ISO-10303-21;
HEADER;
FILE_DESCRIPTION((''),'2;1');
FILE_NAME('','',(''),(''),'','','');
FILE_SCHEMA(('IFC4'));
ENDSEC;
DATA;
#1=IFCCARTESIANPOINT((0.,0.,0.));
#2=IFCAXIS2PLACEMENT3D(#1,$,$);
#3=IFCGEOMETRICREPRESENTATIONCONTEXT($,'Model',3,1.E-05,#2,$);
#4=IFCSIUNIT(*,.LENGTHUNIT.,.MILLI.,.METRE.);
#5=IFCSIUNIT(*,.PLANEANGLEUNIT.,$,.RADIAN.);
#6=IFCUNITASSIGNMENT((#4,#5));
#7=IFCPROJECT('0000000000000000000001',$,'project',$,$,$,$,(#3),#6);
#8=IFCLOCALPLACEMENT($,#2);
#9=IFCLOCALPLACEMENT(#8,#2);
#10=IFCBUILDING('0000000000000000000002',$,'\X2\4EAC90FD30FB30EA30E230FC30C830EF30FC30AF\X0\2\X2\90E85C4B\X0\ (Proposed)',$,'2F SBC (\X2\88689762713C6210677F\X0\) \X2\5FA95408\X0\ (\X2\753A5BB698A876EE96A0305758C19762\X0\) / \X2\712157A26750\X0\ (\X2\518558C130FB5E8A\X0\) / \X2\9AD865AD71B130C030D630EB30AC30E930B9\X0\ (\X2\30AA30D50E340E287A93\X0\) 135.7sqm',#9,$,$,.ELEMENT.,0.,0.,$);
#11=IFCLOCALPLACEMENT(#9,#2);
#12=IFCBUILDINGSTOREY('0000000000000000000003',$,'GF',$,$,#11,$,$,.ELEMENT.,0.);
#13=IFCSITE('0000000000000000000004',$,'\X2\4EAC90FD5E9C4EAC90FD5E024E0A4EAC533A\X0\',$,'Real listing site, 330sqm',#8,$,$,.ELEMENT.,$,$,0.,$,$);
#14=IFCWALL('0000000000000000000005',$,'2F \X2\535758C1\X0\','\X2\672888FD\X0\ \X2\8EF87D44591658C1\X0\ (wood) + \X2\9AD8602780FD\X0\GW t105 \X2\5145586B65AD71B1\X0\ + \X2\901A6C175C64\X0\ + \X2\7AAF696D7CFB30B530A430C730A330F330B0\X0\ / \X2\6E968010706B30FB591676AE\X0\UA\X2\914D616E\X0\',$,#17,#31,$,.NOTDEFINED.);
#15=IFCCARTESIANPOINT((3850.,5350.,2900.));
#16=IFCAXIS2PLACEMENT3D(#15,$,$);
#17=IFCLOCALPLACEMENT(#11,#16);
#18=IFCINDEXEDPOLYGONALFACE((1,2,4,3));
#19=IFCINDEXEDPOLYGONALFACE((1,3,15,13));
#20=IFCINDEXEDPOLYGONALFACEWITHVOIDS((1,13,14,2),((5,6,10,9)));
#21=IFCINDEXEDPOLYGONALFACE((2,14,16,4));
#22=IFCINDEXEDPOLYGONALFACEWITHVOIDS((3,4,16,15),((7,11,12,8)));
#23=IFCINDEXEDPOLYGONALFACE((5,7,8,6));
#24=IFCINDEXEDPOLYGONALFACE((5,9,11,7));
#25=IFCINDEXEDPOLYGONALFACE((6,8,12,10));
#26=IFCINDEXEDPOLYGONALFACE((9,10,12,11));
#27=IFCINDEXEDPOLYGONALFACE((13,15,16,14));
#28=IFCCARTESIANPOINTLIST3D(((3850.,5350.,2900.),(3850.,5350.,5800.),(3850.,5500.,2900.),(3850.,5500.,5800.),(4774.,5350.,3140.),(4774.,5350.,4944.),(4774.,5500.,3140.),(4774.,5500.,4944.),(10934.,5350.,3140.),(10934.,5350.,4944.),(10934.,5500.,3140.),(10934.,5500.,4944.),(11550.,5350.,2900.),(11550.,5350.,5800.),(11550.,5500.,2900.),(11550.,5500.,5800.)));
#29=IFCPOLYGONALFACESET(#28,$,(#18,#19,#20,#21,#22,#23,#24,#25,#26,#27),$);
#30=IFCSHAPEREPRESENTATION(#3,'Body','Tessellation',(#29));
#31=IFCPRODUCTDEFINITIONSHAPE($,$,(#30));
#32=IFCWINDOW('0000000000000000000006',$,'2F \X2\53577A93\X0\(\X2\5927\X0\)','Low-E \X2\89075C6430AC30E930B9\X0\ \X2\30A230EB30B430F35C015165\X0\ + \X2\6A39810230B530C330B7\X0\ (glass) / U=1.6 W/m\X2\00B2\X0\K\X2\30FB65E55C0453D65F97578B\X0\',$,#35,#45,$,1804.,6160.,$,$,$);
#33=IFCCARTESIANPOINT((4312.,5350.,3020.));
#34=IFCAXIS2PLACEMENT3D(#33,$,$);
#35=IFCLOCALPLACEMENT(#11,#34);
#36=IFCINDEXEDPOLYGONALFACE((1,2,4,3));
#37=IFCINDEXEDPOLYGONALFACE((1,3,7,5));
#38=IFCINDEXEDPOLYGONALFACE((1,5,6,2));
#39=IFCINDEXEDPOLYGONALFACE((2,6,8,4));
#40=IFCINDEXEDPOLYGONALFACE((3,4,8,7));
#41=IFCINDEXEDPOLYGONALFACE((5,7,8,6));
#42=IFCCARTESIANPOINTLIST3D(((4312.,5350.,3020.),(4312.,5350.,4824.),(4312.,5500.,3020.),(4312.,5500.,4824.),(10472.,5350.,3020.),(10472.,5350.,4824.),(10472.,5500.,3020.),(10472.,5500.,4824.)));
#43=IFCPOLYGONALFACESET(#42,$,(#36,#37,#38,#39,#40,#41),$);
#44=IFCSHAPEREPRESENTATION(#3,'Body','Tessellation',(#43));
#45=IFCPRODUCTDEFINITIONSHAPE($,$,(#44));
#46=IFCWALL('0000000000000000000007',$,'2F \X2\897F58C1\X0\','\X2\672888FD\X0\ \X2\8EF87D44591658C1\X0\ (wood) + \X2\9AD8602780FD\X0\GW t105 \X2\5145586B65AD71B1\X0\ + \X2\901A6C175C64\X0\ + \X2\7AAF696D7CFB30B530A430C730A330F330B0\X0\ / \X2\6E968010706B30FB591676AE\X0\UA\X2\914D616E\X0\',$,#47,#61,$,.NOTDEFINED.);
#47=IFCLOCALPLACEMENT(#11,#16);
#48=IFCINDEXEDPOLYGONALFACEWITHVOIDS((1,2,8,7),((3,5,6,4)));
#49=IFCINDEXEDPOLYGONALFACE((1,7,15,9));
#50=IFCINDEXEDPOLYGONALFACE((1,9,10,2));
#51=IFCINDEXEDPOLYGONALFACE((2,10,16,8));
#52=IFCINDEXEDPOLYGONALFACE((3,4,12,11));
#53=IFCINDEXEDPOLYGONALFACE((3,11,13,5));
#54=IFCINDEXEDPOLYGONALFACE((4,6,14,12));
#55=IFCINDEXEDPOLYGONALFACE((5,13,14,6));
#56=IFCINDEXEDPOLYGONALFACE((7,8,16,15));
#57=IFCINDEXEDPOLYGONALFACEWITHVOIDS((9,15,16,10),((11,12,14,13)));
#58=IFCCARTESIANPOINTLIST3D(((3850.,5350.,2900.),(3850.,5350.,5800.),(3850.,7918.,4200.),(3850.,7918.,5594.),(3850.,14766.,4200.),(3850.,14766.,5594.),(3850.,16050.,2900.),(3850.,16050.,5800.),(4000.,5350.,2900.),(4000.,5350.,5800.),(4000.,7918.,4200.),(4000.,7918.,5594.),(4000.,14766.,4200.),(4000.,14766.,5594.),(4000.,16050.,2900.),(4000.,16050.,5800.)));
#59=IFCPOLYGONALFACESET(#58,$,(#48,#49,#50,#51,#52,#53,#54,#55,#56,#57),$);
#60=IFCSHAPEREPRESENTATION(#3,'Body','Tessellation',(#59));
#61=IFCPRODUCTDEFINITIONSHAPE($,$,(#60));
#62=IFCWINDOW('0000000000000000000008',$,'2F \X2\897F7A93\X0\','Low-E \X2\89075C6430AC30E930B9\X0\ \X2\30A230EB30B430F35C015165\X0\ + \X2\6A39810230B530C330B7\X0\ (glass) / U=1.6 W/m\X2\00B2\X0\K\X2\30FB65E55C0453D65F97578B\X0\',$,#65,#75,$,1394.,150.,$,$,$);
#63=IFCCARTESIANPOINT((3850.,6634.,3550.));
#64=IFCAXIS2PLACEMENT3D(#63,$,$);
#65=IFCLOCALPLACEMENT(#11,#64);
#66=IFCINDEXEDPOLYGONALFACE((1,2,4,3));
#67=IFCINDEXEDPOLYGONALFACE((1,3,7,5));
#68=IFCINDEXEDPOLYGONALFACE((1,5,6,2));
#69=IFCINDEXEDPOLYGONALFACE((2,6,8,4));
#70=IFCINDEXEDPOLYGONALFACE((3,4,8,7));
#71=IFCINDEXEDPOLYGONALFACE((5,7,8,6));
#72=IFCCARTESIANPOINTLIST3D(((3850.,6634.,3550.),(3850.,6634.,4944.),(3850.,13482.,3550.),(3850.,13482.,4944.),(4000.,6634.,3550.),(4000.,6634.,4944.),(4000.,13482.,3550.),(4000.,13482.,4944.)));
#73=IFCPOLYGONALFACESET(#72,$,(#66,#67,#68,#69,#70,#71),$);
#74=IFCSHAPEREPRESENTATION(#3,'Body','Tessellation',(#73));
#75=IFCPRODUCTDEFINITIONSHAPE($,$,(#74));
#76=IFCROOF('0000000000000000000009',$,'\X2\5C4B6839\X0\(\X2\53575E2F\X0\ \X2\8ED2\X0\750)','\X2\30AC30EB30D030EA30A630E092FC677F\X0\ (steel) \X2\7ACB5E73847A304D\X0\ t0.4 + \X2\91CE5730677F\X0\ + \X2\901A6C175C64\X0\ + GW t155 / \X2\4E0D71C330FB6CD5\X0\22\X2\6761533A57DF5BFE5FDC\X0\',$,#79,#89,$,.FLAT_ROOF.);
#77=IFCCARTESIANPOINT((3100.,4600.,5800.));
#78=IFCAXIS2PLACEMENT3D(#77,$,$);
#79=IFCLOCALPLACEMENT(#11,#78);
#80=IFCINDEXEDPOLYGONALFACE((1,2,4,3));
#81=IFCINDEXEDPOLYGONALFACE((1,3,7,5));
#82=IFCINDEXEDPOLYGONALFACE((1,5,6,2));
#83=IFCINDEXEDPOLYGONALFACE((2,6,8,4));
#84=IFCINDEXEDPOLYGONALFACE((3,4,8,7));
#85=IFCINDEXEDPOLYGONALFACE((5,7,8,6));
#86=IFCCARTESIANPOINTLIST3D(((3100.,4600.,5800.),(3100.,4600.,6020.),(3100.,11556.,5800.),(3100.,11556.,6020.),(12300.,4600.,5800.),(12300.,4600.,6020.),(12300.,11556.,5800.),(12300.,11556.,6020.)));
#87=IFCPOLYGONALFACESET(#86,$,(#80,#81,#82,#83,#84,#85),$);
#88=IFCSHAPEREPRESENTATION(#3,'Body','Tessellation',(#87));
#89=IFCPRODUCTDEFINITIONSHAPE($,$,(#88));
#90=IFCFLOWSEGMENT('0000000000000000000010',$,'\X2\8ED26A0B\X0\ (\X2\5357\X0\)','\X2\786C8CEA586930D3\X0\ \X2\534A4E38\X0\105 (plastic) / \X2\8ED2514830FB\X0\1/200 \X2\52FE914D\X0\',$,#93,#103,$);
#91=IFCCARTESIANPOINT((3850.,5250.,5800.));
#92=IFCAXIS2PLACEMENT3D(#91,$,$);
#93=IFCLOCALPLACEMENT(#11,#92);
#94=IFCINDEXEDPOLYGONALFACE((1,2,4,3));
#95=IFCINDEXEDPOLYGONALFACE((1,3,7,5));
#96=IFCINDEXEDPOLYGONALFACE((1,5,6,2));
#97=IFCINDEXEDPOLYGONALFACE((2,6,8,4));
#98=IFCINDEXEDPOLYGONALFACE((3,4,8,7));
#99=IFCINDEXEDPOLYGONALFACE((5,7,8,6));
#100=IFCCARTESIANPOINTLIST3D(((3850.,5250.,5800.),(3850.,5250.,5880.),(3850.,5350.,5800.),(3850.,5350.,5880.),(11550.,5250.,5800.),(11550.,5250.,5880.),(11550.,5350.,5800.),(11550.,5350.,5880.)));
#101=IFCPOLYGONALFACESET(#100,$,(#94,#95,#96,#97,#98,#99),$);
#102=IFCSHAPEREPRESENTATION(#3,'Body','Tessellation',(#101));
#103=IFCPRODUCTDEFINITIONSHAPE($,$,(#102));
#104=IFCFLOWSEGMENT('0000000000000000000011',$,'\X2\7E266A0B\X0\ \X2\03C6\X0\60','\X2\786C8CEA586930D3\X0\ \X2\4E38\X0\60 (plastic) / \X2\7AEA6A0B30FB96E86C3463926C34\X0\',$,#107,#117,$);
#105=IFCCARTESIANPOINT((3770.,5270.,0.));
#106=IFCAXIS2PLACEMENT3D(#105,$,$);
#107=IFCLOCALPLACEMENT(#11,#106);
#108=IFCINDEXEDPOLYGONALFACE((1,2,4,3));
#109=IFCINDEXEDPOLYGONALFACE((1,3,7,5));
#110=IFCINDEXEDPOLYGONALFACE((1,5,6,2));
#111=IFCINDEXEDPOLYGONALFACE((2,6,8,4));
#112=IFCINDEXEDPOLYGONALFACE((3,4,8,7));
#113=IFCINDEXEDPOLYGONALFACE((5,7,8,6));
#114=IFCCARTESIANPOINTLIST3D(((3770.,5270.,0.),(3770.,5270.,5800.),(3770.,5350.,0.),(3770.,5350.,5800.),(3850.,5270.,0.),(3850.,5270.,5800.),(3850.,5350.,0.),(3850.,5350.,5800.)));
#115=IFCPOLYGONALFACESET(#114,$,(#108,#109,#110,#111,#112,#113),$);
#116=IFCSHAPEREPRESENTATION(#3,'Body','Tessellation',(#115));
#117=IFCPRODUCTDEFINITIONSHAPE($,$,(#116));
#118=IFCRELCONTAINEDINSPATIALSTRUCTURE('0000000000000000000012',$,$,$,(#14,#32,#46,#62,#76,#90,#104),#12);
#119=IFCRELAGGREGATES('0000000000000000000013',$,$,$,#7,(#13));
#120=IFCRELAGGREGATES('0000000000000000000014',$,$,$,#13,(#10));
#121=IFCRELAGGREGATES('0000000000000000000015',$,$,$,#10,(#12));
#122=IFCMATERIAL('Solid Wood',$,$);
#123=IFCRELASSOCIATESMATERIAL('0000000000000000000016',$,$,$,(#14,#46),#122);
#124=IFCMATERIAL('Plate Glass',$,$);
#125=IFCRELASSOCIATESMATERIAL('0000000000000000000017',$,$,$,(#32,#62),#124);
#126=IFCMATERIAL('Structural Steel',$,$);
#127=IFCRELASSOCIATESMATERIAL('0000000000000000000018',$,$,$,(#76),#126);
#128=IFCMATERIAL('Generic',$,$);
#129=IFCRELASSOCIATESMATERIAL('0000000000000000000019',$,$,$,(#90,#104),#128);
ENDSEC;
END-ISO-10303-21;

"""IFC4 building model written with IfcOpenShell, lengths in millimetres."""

from ifc_helpers import new_model, si_unit, frame, frame_2d, origin, place, context, project, spatial, rectangle, extrude, material, element, fill, save


model = new_model("IFC4")

# Units and contexts
model_context = context("Model", 3, precision=1e-05, world=origin())
ifc_project = project(units=[si_unit("LENGTHUNIT", "METRE", prefix="MILLI"), si_unit("PLANEANGLEUNIT", "RADIAN")], contexts=[model_context])

# Site, building, storey
site_placement = place(None, origin())
site = spatial("IfcSite", under=ifc_project, at=site_placement, Name="京都府京都市上京区", ObjectType="Real listing site, 330sqm", CompositionType="ELEMENT", RefElevation=0.0)
building_placement = place(site_placement, origin())
building = spatial("IfcBuilding", under=site, at=building_placement, Name="京都・リモートワーク2部屋 (Proposed)", ObjectType="2F SBC (表面焼成板) 復合 (町家風目隠し壁面) / 無垢材 (内壁・床) / 高断熱ダブルガラス (オフิศ窓) 135.7sqm", CompositionType="ELEMENT", ElevationOfRefHeight=0.0, ElevationOfTerrain=0.0)
storey_placement = place(building_placement, origin())
storey = spatial("IfcBuildingStorey", under=building, at=storey_placement, Name="GF", CompositionType="ELEMENT", Elevation=0.0)

# Shared definitions
ifc_material_1 = material(Name="Solid Wood")

# Shared definitions
ifc_material_2 = material(Name="Plate Glass")

# Walls, openings, windows
wall_1_placement = place(storey_placement, frame((3850.0, 5350.0, 2900.0)))
wall_1 = element("IfcWall", 1, at=wall_1_placement, inside=storey, material=ifc_material_1, Name="2F 南壁", Description="木製 軸組外壁 (wood) + 高性能GW t105 充填断熱 + 通気層 + 窯業系サイディング / 準耐火・外皮UA配慮", PredefinedType="NOTDEFINED", context=model_context, shape_type="SweptSolid", body=[
    extrude(rectangle(XDim=7700.0, YDim=150.0, at=frame_2d((3850.0, 75.0))), frame((3850.0, 5350.0, 2900.0)), (0.0, 0.0, 1.0), 2900.0),
])
opening_1_placement = place(storey_placement, frame((4312.0, 5350.0, 3020.0)))
opening_1 = element("IfcOpeningElement", 2, at=opening_1_placement, cuts=wall_1, PredefinedType="NOTDEFINED", context=model_context, shape_type="SweptSolid", body=[
    extrude(rectangle(XDim=6160.0, YDim=150.0, at=frame_2d((3080.0, 75.0))), frame((4312.0, 5350.0, 3020.0)), (0.0, 0.0, 1.0), 1804.0),
])
window_1_placement = place(storey_placement, frame((4312.0, 5350.0, 3020.0)))
window_1 = element("IfcWindow", 3, at=window_1_placement, inside=storey, material=ifc_material_2, Name="2F 南窓(大)", Description="Low-E 複層ガラス アルゴン封入 + 樹脂サッシ (glass) / U=1.6 W/m²K・日射取得型", OverallHeight=1804.0, OverallWidth=6160.0, context=model_context, shape_type="SweptSolid", body=[
    extrude(rectangle(XDim=6160.0, YDim=150.0, at=frame_2d((3080.0, 75.0))), frame((4312.0, 5350.0, 3020.0)), (0.0, 0.0, 1.0), 1804.0),
])
fill(opening_1, window_1)
wall_2_placement = place(storey_placement, frame((3850.0, 5350.0, 2900.0)))
wall_2 = element("IfcWall", 4, at=wall_2_placement, inside=storey, material=ifc_material_1, Name="2F 西壁", Description="木製 軸組外壁 (wood) + 高性能GW t105 充填断熱 + 通気層 + 窯業系サイディング / 準耐火・外皮UA配慮", PredefinedType="NOTDEFINED", context=model_context, shape_type="SweptSolid", body=[
    extrude(rectangle(XDim=150.0, YDim=10700.0, at=frame_2d((75.0, 5350.0))), frame((3850.0, 5350.0, 2900.0)), (0.0, 0.0, 1.0), 2900.0),
])
opening_2_placement = place(storey_placement, frame((3850.0, 6634.0, 3550.0)))
opening_2 = element("IfcOpeningElement", 5, at=opening_2_placement, cuts=wall_2, PredefinedType="NOTDEFINED", context=model_context, shape_type="SweptSolid", body=[
    extrude(rectangle(XDim=150.0, YDim=6848.0, at=frame_2d((75.0, 3424.0))), frame((3850.0, 6634.0, 3550.0)), (0.0, 0.0, 1.0), 1394.0),
])
window_2_placement = place(storey_placement, frame((3850.0, 6634.0, 3550.0)))
window_2 = element("IfcWindow", 6, at=window_2_placement, inside=storey, material=ifc_material_2, Name="2F 西窓", Description="Low-E 複層ガラス アルゴン封入 + 樹脂サッシ (glass) / U=1.6 W/m²K・日射取得型", OverallHeight=1394.0, OverallWidth=150.0, context=model_context, shape_type="SweptSolid", body=[
    extrude(rectangle(XDim=150.0, YDim=6848.0, at=frame_2d((75.0, 3424.0))), frame((3850.0, 6634.0, 3550.0)), (0.0, 0.0, 1.0), 1394.0),
])
fill(opening_2, window_2)

# Roof
ifc_material_3 = material(Name="Structural Steel")
for number, where, name in (
    (7, (3100.0, 4600.0, 5800.0), "屋根(南帯 軒750)"),
):
    element("IfcRoof", number, at=place(storey_placement, frame(where)), inside=storey, material=ifc_material_3, Name=name, Description="ガルバリウム鋼板 (steel) 立平葺き t0.4 + 野地板 + 通気層 + GW t155 / 不燃・法22条区域対応", PredefinedType="FLAT_ROOF", context=model_context, shape_type="SweptSolid", body=[
        extrude(rectangle(XDim=9200.0, YDim=6956.0, at=frame_2d((4600.0, 3478.0))), frame((3100.0, 4600.0, 5800.0)), (0.0, 0.0, 1.0), 220.0),
    ])

# Flow segments
ifc_material_4 = material(Name="Generic")
flow_segment_1_placement = place(storey_placement, frame((3850.0, 5250.0, 5800.0)))
element("IfcFlowSegment", 8, at=flow_segment_1_placement, inside=storey, material=ifc_material_4, Name="軒樋 (南)", Description="硬質塩ビ 半丸105 (plastic) / 軒先・1/200 勾配", context=model_context, shape_type="SweptSolid", body=[
    extrude(rectangle(XDim=7700.0, YDim=100.0, at=frame_2d((3850.0, 50.0))), frame((3850.0, 5250.0, 5800.0)), (0.0, 0.0, 1.0), 80.0),
])
flow_segment_2_placement = place(storey_placement, frame((3770.0, 5270.0, 0.0)))
element("IfcFlowSegment", 9, at=flow_segment_2_placement, inside=storey, material=ifc_material_4, Name="縦樋 φ60", Description="硬質塩ビ 丸60 (plastic) / 竪樋・雨水排水", context=model_context, shape_type="SweptSolid", body=[
    extrude(rectangle(XDim=80.0, YDim=80.0, at=frame_2d((40.0, 40.0))), frame((3770.0, 5270.0, 0.0)), (0.0, 0.0, 1.0), 5800.0),
])

save(model, "model.ifc")
